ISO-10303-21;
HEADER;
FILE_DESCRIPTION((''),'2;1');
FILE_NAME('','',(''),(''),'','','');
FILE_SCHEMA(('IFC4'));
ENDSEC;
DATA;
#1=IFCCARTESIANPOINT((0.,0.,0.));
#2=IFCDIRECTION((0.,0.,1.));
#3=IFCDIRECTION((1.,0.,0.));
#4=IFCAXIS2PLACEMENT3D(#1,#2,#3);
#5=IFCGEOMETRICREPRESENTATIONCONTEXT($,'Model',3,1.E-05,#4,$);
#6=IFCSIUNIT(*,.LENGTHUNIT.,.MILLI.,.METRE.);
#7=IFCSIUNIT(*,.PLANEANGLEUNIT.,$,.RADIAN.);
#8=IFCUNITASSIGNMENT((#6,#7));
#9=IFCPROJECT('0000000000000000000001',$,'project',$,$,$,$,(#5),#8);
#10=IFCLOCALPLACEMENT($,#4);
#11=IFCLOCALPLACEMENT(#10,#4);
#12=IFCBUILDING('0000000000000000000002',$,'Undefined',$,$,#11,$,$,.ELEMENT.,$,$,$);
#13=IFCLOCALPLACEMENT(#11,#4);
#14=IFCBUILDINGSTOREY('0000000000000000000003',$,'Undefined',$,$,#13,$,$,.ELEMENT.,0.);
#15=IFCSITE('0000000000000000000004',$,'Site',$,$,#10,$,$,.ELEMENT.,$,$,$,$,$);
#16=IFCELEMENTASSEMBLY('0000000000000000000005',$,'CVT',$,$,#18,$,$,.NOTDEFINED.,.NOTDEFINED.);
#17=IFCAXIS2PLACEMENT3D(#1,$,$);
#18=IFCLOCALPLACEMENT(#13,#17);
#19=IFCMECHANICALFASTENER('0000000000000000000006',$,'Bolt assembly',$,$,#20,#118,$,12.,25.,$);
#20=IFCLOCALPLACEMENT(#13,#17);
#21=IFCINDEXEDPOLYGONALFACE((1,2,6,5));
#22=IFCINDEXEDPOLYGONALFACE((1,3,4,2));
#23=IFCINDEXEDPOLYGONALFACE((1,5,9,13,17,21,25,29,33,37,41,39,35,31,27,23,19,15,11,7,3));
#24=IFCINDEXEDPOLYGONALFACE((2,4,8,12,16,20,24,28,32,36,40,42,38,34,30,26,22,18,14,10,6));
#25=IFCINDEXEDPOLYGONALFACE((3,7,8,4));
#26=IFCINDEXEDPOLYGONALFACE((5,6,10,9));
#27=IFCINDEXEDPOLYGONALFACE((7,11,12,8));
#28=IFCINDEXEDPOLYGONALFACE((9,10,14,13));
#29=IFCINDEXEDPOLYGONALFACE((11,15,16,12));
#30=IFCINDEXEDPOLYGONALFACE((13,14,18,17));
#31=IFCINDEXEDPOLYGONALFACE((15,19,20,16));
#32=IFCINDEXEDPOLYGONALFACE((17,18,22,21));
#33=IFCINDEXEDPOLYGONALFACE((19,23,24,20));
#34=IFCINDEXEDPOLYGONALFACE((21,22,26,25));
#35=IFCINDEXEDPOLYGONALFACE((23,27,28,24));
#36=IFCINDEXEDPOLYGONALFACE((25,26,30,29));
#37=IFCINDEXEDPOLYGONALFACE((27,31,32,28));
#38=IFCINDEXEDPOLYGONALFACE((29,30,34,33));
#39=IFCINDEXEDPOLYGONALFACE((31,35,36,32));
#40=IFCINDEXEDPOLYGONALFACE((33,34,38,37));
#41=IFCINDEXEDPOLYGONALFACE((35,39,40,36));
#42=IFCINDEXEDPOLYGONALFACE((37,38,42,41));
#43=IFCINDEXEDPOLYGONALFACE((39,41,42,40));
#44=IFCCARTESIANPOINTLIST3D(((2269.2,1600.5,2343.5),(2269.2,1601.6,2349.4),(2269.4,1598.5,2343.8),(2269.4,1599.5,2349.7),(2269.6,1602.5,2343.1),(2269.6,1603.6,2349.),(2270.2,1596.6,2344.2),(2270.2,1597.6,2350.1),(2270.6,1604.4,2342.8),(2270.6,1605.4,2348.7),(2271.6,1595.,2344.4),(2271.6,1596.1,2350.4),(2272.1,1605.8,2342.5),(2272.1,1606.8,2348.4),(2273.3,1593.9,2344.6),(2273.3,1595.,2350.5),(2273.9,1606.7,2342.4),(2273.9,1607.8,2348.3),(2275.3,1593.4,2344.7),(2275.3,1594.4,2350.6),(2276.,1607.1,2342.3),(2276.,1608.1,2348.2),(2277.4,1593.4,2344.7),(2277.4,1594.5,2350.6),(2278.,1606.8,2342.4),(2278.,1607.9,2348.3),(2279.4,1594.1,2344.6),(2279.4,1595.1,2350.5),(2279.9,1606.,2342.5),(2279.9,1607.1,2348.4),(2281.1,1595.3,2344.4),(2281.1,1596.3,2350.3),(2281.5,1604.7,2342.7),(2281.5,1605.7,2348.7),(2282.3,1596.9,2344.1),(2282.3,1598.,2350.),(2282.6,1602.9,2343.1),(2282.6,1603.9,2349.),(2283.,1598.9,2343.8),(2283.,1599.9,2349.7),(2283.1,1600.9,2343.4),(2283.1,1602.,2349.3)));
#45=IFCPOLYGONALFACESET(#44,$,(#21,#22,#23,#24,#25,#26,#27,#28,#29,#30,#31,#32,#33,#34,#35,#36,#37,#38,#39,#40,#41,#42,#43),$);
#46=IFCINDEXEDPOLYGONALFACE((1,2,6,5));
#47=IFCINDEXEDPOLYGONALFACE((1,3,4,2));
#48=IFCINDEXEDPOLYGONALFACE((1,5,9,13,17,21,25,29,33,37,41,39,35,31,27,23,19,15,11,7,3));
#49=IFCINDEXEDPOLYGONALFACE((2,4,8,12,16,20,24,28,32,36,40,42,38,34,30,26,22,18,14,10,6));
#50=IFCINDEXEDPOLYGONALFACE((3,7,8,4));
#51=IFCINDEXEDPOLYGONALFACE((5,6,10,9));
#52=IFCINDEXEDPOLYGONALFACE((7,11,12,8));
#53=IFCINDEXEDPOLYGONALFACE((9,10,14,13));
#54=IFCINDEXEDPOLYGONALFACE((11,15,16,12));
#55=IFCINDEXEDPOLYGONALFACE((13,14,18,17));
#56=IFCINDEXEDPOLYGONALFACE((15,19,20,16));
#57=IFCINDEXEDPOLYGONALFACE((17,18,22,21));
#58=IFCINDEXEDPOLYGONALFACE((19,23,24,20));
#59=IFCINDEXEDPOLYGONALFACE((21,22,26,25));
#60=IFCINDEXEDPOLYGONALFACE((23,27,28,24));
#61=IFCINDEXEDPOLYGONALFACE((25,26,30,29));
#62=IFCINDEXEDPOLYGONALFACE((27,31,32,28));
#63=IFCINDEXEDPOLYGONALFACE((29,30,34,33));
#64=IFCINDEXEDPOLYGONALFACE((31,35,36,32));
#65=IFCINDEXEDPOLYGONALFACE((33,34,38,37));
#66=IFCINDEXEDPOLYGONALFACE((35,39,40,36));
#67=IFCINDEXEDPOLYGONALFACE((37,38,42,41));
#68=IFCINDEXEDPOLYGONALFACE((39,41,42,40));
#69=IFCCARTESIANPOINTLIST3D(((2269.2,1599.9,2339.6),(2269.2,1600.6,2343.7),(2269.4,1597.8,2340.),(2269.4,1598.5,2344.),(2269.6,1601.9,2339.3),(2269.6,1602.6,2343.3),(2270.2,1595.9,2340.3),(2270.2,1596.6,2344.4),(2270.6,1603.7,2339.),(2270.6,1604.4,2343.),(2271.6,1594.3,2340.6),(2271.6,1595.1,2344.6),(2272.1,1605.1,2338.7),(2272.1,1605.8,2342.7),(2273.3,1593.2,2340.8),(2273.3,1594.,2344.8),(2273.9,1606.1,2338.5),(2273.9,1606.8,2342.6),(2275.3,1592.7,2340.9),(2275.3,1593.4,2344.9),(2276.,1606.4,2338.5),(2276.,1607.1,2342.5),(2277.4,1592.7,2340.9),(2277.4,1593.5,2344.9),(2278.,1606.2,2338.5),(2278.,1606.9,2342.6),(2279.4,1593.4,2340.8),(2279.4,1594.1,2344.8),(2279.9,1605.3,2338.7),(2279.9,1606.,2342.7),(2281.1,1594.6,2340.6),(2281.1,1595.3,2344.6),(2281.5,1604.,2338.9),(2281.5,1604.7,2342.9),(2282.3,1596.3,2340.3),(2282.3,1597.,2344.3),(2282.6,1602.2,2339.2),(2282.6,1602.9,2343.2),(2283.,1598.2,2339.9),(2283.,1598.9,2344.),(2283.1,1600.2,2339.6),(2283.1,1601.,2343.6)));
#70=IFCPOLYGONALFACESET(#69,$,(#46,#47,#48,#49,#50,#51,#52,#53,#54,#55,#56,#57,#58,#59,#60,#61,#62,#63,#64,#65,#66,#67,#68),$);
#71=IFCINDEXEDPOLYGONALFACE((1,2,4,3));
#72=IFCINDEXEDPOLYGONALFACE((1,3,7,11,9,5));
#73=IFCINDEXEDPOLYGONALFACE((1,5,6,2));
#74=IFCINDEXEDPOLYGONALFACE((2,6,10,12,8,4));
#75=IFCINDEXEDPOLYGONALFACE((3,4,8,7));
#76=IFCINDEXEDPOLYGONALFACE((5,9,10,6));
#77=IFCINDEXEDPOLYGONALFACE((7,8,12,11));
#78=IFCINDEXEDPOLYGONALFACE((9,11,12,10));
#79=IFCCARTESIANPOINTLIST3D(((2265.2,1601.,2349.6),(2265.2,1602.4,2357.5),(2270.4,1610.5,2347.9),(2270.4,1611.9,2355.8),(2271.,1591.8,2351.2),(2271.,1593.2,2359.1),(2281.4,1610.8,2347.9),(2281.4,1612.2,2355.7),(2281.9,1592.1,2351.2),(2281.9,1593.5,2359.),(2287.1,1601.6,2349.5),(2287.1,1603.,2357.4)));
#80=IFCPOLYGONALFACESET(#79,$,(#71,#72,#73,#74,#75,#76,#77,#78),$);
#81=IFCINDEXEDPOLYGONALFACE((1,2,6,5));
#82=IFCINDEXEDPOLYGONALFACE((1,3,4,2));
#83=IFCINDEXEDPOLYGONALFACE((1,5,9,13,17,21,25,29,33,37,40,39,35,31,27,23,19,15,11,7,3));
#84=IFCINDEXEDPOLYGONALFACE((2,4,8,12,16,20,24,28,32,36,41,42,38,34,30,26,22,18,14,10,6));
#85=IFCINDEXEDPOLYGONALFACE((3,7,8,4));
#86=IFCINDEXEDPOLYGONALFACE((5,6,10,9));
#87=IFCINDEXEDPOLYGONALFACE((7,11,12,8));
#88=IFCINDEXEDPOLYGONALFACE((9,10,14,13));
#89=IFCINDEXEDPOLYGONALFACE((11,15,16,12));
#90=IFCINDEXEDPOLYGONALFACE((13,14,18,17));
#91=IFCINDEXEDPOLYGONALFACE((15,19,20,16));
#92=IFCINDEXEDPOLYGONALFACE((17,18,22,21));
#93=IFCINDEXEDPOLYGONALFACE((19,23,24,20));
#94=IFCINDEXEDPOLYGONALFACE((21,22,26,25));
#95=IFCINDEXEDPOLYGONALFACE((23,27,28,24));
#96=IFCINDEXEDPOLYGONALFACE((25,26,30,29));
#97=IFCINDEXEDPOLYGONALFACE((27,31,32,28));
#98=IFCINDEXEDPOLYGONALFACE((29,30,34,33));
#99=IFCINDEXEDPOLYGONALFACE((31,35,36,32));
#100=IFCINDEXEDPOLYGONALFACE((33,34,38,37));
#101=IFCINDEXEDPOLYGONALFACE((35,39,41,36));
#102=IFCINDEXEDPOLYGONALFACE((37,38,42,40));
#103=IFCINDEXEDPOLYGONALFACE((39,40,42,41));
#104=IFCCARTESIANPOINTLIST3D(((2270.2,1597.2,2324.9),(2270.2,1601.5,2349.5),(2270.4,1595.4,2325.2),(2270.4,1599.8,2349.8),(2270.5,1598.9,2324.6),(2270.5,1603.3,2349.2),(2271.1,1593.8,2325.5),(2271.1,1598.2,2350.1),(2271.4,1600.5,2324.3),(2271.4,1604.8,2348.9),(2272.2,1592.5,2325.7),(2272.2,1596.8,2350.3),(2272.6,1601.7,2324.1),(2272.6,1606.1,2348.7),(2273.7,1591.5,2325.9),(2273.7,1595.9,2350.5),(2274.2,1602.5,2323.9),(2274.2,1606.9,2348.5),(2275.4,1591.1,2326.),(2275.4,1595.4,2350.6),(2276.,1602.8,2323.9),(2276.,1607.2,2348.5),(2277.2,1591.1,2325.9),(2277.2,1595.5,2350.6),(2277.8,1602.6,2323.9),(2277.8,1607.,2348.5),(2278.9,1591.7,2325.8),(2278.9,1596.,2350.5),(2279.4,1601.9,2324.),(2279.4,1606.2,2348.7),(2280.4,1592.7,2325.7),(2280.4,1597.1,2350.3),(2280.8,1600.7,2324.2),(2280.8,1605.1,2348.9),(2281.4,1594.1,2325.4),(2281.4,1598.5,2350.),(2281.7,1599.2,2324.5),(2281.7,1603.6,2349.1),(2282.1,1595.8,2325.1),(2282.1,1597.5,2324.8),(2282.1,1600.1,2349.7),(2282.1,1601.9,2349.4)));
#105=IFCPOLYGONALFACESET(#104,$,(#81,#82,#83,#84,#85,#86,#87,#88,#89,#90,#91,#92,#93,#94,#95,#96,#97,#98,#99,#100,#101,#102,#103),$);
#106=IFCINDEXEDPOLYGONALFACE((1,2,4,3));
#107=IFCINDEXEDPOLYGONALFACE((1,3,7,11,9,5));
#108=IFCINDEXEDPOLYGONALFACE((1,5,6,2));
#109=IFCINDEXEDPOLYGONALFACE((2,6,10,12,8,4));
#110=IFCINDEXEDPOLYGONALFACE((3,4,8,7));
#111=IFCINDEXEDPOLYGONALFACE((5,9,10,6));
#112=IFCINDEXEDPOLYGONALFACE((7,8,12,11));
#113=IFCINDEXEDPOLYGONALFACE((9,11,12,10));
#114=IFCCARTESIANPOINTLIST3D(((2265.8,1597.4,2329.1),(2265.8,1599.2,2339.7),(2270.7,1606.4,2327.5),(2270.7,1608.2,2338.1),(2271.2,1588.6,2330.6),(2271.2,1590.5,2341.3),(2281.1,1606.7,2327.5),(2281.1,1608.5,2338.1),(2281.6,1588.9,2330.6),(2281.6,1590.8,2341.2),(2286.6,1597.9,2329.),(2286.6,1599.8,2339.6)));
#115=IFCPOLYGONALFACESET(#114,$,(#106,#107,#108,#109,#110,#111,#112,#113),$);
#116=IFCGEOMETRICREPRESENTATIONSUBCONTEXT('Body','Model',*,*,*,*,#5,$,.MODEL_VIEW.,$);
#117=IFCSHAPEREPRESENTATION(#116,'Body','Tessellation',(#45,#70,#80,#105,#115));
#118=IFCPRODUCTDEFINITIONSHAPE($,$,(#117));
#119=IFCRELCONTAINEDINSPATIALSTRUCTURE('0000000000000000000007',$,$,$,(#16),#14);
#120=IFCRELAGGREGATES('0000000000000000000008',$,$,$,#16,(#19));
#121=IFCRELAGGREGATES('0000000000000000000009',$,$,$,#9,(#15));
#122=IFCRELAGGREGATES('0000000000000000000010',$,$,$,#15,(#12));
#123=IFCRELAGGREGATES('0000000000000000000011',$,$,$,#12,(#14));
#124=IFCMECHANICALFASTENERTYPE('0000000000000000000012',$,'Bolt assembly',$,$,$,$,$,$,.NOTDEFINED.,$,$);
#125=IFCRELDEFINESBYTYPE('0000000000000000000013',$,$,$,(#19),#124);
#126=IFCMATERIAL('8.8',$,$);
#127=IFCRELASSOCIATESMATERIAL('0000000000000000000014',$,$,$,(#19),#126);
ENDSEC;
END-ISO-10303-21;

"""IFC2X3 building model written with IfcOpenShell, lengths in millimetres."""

from ifc_helpers import new_model, si_unit, frame, origin_with_axes, origin_2d_with_axis, place, context, subcontext, project, spatial, polyline, circle, outline, extrude, source, transform, mapped, material, type_object, element, aggregate, save


model = new_model("IFC2X3")

# Units and contexts
model_context = context("Model", 3, precision=1e-05, world=origin_with_axes())
body_context = subcontext(model_context, "Body", "Model", "MODEL_VIEW")
ifc_project = project(units=[si_unit("LENGTHUNIT", "METRE", prefix="MILLI"), si_unit("PLANEANGLEUNIT", "RADIAN")], contexts=[model_context])

# Site, building, storey
site_placement = place(None, origin_with_axes())
site = spatial("IfcSite", under=ifc_project, at=site_placement, Name="Site", CompositionType="ELEMENT")
building_placement = place(site_placement, origin_with_axes())
building = spatial("IfcBuilding", under=site, at=building_placement, Name="Undefined", CompositionType="ELEMENT")
storey_placement = place(building_placement, origin_with_axes())
storey = spatial("IfcBuildingStorey", under=building, at=storey_placement, Name="Undefined", CompositionType="ELEMENT", Elevation=0.0)

# Element assembly
assembly_1_placement = place(storey_placement, origin_with_axes())
assembly_1 = element("IfcElementAssembly", 1, at=assembly_1_placement, inside=storey, Name="CVT", AssemblyPlace="NOTDEFINED", PredefinedType="NOTDEFINED")

# Mechanical fastener
ifc_material_1 = material(Name="8.8")
mechanical_fastener_type = type_object("IfcMechanicalFastenerType", Name="Bolt assembly")
shared_shape_1 = source(origin_with_axes(), body_context, "Body", "SweptSolid", [
    extrude(circle(Radius=7.0, at=origin_2d_with_axis()), frame((0.0, -5.9, 0.0), z_axis=(0.0, 1.0, 0.0), x_axis=(1.0, 0.0, 0.0)), (0.0, 0.0, 1.0), 6.0),
    extrude(circle(Radius=7.0, at=origin_2d_with_axis()), frame((0.0, -0.1, 0.0), z_axis=(0.0, 1.0, 0.0), x_axis=(1.0, 0.0, 0.0)), (0.0, 0.0, 1.0), 4.1),
    extrude(outline(polyline([(9.5, -5.5), (9.5, 5.5), (0.0, 11.0), (-9.5, 5.5), (-9.5, -5.5), (0.0, -11.0), (9.5, -5.5)])), frame((0.0, -14.0, 0.0), z_axis=(0.0, 1.0, 0.0), x_axis=(1.0, 0.0, 0.0)), (0.0, 0.0, 1.0), 8.0),
    extrude(circle(Radius=6.0, at=origin_2d_with_axis()), frame((0.0, -6.0, 0.0), z_axis=(0.0, 1.0, 0.0), x_axis=(1.0, 0.0, 0.0)), (0.0, 0.0, 1.0), 25.0),
    extrude(outline(polyline([(9.0, -5.2), (9.0, 5.2), (0.0, 10.4), (-9.0, 5.2), (-9.0, -5.2), (0.0, -10.4), (9.0, -5.2)])), frame((0.0, 4.0, 0.0), z_axis=(0.0, 1.0, 0.0), x_axis=(1.0, 0.0, 0.0)), (0.0, 0.0, 1.0), 10.8),
])
mechanical_fastener_1_placement = place(assembly_1_placement, frame((2276.2, 1600.2, 2343.6), z_axis=(0.475539, 0.866272, -0.153084), x_axis=(0.879695, -0.468284, 0.082753)))
mechanical_fastener_1 = element("IfcMechanicalFastener", 2, at=mechanical_fastener_1_placement, type_object=mechanical_fastener_type, material=ifc_material_1, Name="Bolt assembly", NominalDiameter=12.0, NominalLength=25.0, context=body_context, shape_type="MappedRepresentation", body=[
    mapped(shared_shape_1, transform((0.0, 0.0, 0.0))),
])

aggregate(assembly_1, [mechanical_fastener_1])

save(model, "model.ifc")
